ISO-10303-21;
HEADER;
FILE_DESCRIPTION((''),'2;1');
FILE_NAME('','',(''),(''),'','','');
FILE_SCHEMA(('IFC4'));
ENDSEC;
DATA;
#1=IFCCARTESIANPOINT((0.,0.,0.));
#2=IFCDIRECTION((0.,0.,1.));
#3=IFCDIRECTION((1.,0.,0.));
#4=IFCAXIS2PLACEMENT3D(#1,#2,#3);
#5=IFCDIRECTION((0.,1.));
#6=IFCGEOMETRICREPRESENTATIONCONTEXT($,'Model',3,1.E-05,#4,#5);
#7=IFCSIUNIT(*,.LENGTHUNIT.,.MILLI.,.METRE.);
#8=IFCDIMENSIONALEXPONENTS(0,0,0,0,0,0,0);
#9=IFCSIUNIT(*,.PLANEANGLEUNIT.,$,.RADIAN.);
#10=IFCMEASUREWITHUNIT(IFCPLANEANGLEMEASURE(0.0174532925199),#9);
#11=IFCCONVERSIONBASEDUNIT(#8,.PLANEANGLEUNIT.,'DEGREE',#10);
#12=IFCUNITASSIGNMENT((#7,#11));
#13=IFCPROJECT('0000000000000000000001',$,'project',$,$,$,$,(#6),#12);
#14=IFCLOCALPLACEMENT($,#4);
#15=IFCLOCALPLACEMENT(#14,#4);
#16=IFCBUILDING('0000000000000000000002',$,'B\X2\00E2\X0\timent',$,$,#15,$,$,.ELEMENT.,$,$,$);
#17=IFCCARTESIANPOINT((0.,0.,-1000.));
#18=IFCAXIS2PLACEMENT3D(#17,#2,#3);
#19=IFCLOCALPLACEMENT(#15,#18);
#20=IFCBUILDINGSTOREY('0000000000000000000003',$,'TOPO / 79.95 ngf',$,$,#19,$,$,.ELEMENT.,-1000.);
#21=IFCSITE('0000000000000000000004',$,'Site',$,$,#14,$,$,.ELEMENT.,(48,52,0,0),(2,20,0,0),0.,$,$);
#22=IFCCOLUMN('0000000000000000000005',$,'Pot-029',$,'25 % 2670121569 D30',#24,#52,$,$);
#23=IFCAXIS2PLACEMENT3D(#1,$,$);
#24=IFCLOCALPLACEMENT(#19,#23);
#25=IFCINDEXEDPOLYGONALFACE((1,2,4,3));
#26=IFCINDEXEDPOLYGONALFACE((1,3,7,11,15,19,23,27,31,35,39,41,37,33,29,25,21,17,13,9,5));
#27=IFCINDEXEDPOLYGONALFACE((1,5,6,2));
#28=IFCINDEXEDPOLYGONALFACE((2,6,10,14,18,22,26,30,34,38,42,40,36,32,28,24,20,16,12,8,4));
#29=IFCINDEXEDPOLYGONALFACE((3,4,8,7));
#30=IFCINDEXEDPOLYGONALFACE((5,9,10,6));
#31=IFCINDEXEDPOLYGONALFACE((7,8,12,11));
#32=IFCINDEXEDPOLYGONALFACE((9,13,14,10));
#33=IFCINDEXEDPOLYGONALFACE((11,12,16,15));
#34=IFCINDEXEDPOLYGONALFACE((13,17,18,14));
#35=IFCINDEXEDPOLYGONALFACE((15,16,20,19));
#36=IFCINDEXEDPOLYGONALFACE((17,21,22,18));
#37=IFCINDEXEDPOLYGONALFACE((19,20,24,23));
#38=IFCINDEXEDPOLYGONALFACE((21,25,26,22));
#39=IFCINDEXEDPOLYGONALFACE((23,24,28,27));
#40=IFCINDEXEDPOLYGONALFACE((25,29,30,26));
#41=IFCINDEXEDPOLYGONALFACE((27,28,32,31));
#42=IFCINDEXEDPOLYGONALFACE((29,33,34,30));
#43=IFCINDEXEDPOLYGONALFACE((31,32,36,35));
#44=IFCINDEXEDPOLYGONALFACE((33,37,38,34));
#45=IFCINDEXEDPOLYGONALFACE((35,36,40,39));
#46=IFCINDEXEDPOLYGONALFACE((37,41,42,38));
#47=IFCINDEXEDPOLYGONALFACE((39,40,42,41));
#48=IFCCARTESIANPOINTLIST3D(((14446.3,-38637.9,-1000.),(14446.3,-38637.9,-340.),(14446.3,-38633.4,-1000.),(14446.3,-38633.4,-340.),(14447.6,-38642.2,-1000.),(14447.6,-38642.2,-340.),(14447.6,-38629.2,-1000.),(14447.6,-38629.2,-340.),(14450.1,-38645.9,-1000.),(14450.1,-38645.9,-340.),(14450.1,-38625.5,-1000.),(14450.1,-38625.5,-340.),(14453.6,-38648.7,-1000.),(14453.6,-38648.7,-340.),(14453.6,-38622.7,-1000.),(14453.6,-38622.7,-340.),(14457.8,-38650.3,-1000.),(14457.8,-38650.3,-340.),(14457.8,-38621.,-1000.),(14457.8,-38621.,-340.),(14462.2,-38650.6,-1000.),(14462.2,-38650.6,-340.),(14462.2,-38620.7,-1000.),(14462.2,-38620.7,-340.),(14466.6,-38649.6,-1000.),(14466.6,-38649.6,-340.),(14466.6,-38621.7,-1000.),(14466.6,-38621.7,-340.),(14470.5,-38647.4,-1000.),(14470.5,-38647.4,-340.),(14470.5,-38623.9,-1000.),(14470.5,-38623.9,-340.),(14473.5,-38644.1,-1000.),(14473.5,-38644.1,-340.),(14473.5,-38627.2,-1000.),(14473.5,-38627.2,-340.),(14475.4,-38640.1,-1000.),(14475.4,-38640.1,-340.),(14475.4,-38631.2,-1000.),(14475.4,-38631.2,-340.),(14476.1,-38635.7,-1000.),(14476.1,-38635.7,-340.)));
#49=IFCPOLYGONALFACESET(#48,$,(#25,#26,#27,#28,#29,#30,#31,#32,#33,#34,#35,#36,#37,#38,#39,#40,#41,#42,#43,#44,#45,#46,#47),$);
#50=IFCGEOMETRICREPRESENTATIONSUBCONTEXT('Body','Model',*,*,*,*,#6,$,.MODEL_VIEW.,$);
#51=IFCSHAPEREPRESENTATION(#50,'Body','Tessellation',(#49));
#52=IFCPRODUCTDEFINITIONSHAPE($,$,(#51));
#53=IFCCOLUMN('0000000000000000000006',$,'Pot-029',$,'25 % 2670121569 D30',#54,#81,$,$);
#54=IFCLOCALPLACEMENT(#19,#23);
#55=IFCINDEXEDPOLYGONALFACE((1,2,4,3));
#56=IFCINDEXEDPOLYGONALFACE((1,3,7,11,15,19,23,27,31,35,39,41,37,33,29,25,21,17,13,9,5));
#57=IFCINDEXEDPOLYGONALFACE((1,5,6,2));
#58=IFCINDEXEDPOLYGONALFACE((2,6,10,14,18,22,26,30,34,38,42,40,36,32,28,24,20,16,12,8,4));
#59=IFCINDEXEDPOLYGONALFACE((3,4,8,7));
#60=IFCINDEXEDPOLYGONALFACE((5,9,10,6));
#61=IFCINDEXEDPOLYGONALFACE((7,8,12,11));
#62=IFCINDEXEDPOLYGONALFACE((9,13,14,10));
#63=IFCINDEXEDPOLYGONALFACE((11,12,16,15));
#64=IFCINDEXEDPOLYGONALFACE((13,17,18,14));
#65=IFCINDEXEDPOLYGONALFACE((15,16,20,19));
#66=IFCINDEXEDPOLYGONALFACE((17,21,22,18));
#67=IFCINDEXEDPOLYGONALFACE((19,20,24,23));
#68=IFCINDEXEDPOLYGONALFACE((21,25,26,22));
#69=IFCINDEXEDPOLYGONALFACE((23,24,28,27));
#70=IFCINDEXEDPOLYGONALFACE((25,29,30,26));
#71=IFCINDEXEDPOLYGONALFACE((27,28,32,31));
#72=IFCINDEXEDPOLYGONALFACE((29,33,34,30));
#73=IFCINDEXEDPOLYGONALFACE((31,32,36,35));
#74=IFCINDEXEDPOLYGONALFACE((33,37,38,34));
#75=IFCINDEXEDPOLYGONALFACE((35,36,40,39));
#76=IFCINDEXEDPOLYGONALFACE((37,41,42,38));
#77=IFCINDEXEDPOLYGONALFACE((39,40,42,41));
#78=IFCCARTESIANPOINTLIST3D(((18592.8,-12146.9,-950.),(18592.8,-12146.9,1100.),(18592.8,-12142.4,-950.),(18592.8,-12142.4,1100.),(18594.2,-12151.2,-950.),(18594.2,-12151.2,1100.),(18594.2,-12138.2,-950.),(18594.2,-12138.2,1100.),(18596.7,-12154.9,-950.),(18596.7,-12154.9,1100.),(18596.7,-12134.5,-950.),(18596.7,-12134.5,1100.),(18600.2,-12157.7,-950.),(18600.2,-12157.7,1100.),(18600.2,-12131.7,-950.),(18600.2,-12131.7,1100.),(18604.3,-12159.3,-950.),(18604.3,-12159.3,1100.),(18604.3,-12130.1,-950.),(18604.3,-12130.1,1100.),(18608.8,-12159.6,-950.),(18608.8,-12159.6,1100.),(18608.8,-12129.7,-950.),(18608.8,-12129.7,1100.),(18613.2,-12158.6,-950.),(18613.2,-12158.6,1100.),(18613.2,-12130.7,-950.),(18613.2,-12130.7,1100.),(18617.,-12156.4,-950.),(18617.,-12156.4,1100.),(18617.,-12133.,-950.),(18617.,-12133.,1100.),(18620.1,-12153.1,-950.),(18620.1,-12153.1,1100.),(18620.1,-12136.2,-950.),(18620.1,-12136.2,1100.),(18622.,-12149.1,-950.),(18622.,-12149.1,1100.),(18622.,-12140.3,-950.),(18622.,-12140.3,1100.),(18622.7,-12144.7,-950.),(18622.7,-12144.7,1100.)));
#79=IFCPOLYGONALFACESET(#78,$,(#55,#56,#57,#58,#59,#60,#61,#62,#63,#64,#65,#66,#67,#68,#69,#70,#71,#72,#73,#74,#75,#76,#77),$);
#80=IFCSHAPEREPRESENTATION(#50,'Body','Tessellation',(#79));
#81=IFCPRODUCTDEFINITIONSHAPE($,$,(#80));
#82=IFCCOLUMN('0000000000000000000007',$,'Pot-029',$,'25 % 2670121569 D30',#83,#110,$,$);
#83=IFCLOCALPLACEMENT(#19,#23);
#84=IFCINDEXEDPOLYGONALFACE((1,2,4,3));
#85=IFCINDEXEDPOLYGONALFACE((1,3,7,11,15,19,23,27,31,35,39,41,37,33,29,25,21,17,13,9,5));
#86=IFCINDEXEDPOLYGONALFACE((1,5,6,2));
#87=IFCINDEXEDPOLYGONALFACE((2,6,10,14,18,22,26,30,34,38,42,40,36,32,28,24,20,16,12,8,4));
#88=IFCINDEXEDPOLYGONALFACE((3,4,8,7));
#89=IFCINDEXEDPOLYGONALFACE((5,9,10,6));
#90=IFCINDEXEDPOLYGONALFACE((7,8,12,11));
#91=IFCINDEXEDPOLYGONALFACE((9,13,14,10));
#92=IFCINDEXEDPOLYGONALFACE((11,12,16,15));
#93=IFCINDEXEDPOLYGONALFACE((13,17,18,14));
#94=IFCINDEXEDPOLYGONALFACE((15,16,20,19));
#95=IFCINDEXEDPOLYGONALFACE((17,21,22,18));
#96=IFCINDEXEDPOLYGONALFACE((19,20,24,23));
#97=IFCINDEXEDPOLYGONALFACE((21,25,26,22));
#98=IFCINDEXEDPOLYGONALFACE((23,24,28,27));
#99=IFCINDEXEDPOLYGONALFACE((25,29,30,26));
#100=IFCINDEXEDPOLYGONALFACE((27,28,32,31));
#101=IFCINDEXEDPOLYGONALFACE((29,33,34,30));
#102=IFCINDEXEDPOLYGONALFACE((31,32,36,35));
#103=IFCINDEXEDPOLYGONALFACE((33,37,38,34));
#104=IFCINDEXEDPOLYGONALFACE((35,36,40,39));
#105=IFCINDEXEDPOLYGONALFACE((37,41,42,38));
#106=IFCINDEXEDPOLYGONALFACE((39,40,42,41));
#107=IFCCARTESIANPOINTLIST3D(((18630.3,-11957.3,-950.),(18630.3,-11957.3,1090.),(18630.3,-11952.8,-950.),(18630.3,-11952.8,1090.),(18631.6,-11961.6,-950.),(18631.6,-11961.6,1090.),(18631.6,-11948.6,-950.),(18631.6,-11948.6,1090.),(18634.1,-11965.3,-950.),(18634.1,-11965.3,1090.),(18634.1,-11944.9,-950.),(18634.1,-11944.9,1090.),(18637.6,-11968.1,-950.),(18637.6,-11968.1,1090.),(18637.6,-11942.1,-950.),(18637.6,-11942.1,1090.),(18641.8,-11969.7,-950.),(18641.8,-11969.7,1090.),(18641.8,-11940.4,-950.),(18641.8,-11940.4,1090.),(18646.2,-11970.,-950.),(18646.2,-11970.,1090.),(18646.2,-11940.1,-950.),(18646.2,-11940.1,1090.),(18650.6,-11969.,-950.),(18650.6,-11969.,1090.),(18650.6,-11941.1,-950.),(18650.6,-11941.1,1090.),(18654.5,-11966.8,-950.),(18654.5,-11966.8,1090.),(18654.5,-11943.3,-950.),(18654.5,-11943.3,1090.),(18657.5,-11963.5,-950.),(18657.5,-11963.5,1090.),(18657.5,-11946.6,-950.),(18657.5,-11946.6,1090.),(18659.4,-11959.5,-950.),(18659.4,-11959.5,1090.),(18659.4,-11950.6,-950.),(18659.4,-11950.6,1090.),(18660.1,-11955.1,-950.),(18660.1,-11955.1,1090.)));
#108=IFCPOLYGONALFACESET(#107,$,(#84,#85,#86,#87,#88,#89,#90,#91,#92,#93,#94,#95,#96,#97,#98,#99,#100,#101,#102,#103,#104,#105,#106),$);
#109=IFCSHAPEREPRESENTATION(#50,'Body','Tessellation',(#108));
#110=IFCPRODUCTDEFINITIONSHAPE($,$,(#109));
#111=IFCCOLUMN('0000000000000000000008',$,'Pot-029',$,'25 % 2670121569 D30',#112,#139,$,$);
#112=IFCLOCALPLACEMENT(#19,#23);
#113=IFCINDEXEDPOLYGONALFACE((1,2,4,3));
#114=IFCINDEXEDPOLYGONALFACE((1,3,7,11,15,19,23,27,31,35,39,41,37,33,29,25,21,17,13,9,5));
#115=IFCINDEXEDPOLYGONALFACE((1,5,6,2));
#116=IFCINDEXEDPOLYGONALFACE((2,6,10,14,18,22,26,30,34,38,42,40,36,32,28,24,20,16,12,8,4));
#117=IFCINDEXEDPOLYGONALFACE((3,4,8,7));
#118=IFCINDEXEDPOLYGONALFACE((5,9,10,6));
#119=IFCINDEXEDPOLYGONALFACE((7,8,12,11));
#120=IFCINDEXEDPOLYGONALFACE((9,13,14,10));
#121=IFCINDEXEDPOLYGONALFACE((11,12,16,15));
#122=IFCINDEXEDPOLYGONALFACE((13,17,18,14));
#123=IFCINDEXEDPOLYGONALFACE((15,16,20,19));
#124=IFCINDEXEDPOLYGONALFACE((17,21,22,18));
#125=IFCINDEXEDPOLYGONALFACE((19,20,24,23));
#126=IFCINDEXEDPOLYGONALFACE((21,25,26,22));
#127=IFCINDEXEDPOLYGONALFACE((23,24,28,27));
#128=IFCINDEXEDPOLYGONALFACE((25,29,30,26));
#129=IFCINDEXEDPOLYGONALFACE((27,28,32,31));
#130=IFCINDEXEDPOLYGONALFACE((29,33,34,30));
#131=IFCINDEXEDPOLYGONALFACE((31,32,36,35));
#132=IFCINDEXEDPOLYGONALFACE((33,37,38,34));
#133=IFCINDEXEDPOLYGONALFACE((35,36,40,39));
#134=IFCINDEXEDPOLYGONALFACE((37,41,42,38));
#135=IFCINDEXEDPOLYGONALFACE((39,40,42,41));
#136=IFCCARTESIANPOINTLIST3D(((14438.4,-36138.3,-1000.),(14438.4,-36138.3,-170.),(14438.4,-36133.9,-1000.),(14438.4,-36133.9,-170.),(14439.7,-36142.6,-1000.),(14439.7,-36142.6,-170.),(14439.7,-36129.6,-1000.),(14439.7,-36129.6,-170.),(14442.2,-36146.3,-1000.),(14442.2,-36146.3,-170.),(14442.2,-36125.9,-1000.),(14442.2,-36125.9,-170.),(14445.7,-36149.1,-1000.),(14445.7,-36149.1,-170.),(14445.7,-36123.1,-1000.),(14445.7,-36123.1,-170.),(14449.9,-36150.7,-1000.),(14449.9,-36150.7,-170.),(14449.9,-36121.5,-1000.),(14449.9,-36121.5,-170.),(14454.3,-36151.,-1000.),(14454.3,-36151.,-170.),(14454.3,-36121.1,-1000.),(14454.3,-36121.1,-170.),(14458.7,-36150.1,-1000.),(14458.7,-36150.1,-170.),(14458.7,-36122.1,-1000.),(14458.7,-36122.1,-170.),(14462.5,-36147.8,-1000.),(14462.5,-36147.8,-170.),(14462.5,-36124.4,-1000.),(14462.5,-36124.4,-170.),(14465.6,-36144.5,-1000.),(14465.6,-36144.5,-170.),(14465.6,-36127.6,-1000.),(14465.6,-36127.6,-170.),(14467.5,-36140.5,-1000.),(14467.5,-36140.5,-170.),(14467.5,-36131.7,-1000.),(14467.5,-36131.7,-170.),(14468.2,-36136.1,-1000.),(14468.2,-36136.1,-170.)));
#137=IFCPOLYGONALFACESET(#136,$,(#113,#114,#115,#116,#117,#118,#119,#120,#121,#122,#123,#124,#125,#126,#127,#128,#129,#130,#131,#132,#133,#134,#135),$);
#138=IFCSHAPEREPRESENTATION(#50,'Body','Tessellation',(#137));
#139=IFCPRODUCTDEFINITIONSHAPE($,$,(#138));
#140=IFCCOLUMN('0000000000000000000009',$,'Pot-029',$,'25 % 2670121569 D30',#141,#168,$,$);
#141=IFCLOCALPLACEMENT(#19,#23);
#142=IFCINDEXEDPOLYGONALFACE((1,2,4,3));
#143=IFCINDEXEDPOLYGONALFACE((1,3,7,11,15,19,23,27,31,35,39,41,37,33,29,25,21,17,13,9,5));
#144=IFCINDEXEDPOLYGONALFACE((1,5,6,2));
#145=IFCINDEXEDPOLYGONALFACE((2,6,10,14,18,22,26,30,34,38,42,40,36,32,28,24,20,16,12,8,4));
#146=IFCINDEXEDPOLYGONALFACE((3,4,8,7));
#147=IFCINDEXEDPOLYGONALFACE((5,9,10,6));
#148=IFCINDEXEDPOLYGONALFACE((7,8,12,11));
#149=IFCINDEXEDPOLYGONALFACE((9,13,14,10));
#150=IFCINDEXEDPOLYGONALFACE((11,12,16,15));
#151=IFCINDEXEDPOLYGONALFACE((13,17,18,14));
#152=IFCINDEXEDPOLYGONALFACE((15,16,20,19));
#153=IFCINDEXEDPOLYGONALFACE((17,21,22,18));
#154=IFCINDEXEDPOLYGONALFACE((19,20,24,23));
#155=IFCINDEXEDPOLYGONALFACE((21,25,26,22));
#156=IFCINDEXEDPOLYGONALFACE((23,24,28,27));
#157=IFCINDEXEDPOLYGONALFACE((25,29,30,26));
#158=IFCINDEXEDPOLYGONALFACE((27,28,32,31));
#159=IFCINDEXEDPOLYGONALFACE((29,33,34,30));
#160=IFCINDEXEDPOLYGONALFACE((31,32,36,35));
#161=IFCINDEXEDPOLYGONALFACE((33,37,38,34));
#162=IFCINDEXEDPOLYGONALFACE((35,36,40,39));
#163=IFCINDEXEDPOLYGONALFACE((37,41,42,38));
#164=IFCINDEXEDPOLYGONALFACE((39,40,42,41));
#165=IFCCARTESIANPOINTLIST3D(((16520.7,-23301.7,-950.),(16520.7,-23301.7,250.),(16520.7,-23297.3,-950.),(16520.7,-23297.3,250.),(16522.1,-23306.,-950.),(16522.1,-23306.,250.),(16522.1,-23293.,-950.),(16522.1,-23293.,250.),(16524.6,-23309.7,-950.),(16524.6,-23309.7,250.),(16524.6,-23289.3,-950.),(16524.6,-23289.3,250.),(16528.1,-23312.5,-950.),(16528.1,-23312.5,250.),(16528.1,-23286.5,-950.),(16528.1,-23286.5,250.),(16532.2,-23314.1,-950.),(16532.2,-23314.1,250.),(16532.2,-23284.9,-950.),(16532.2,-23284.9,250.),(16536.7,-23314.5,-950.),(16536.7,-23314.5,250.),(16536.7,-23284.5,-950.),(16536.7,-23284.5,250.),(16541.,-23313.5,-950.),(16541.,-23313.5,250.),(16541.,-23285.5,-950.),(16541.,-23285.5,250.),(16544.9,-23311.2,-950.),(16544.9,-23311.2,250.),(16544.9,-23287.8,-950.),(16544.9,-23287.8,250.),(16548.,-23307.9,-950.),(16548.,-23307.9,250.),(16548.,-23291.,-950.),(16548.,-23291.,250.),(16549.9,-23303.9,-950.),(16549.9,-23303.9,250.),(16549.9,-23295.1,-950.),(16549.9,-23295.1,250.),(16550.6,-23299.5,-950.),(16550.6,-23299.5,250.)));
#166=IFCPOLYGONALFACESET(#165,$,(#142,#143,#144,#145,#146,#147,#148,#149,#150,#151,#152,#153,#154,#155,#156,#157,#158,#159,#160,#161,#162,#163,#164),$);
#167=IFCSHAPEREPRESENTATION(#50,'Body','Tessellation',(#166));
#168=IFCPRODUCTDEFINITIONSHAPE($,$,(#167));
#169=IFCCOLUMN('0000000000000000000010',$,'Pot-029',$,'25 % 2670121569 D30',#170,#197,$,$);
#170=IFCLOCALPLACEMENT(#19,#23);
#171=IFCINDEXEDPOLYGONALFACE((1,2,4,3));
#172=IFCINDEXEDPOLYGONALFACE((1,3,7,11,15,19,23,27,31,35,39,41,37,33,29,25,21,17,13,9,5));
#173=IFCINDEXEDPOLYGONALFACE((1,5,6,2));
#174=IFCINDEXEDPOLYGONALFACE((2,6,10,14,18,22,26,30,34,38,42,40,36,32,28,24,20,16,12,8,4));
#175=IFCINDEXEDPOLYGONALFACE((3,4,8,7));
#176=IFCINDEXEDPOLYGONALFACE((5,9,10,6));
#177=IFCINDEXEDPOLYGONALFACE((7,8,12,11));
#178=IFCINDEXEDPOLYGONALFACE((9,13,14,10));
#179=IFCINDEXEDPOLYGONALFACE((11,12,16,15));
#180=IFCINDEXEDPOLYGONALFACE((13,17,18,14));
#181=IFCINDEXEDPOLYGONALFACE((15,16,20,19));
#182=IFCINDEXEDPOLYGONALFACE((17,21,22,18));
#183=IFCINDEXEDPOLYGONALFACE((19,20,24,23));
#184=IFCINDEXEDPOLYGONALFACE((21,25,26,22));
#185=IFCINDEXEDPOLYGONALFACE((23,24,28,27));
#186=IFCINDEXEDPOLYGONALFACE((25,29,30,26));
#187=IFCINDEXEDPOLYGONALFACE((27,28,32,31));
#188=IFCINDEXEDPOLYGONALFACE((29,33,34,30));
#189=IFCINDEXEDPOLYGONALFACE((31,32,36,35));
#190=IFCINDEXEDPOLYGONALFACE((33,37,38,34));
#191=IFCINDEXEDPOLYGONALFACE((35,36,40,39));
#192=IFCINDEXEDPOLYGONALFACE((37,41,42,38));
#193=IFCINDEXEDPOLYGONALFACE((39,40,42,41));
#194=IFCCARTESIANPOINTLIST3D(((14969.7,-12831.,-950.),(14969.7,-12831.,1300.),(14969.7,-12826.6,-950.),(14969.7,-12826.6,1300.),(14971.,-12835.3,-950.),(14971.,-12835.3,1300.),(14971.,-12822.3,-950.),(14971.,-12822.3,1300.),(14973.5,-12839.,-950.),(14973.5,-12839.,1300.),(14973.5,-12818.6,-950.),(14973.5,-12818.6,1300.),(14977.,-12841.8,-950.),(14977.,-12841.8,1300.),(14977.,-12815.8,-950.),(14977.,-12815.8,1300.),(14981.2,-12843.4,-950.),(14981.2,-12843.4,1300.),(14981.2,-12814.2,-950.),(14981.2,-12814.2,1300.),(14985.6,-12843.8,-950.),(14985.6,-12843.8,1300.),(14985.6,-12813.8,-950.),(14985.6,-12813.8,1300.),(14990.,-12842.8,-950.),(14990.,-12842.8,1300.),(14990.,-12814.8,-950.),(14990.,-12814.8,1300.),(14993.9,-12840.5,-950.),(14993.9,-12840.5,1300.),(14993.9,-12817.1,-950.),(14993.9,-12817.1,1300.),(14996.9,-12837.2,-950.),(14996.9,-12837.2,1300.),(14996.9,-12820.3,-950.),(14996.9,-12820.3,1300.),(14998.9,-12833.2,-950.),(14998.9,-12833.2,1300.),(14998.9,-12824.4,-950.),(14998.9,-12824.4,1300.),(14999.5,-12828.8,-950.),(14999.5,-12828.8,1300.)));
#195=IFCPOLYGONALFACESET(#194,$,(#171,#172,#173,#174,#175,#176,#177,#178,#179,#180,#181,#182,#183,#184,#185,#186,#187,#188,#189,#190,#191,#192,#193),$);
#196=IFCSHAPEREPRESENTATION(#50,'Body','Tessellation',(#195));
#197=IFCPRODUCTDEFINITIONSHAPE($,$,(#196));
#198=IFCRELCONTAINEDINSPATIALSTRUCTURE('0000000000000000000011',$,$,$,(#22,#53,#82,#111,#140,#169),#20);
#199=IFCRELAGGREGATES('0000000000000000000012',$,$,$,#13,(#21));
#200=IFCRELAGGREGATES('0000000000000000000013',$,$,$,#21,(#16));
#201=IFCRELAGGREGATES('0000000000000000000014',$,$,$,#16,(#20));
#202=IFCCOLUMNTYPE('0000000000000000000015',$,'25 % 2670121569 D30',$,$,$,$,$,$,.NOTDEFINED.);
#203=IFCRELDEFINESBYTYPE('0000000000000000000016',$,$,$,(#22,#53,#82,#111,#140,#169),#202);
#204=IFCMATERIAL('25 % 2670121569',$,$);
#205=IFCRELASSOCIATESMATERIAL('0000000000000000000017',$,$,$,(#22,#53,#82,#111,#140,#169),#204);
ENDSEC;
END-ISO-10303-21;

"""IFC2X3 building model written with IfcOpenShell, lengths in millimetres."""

from ifc_helpers import new_model, entity, si_unit, converted_unit, direction, frame, origin_with_axes, origin_2d_with_axis, place, context, subcontext, project, spatial, circle, extrude, material, type_object, element, save


model = new_model("IFC2X3")

# Units and contexts
model_context = context("Model", 3, precision=1e-05, world=origin_with_axes(), true_north=direction((0.0, 1.0)))
body_context = subcontext(model_context, "Body", "Model", "MODEL_VIEW")
ifc_project = project(units=[si_unit("LENGTHUNIT", "METRE", prefix="MILLI"), converted_unit("PLANEANGLEUNIT", "DEGREE", entity("IfcPlaneAngleMeasure", 0.0174532925199), si_unit("PLANEANGLEUNIT", "RADIAN"), dimensions=[0, 0, 0, 0, 0, 0, 0])], contexts=[model_context])

# Site, building, storey
site_placement = place(None, origin_with_axes())
site = spatial("IfcSite", under=ifc_project, at=site_placement, Name="Site", CompositionType="ELEMENT", RefLatitude=(48, 52, 0, 0), RefLongitude=(2, 20, 0, 0), RefElevation=0.0)
building_placement = place(site_placement, origin_with_axes())
building = spatial("IfcBuilding", under=site, at=building_placement, Name="Bâtiment", CompositionType="ELEMENT")
storey_placement = place(building_placement, frame((0.0, 0.0, -1000.0), z_axis=(0.0, 0.0, 1.0), x_axis=(1.0, 0.0, 0.0)))
storey = spatial("IfcBuildingStorey", under=building, at=storey_placement, Name="TOPO / 79.95 ngf", CompositionType="ELEMENT", Elevation=-1000.0)

# Columns
ifc_material_1 = material(Name="25 % 2670121569")
column_type = type_object("IfcColumnType", Name="25 % 2670121569 D30", PredefinedType="NOTDEFINED")
column_1_placement = place(storey_placement, frame((14461.1, -38635.7, -1000.0), z_axis=(0.0, 0.0, 1.0), x_axis=(1.0, 0.0, 0.0)))
element("IfcColumn", 1, at=column_1_placement, inside=storey, type_object=column_type, material=ifc_material_1, Name="Pot-029", ObjectType="25 % 2670121569 D30", context=body_context, shape_type="SweptSolid", body=[
    extrude(circle(Radius=15.0, at=origin_2d_with_axis()), origin_with_axes(), (0.0, 0.0, 1.0), 660.0),
])
column_2_placement = place(storey_placement, frame((18607.7, -12144.7, -950.0), z_axis=(0.0, 0.0, 1.0), x_axis=(1.0, 0.0, 0.0)))
element("IfcColumn", 2, at=column_2_placement, inside=storey, type_object=column_type, material=ifc_material_1, Name="Pot-029", ObjectType="25 % 2670121569 D30", context=body_context, shape_type="SweptSolid", body=[
    extrude(circle(Radius=15.0, at=origin_2d_with_axis()), origin_with_axes(), (0.0, 0.0, 1.0), 2050.0),
])
column_3_placement = place(storey_placement, frame((18645.1, -11955.1, -950.0), z_axis=(0.0, 0.0, 1.0), x_axis=(1.0, 0.0, 0.0)))
element("IfcColumn", 3, at=column_3_placement, inside=storey, type_object=column_type, material=ifc_material_1, Name="Pot-029", ObjectType="25 % 2670121569 D30", context=body_context, shape_type="SweptSolid", body=[
    extrude(circle(Radius=15.0, at=origin_2d_with_axis()), origin_with_axes(), (0.0, 0.0, 1.0), 2040.0),
])
column_4_placement = place(storey_placement, frame((14453.2, -36136.1, -1000.0), z_axis=(0.0, 0.0, 1.0), x_axis=(1.0, 0.0, 0.0)))
element("IfcColumn", 4, at=column_4_placement, inside=storey, type_object=column_type, material=ifc_material_1, Name="Pot-029", ObjectType="25 % 2670121569 D30", context=body_context, shape_type="SweptSolid", body=[
    extrude(circle(Radius=15.0, at=origin_2d_with_axis()), origin_with_axes(), (0.0, 0.0, 1.0), 830.0),
])
column_5_placement = place(storey_placement, frame((16535.6, -23299.5, -950.0), z_axis=(0.0, 0.0, 1.0), x_axis=(1.0, 0.0, 0.0)))
element("IfcColumn", 5, at=column_5_placement, inside=storey, type_object=column_type, material=ifc_material_1, Name="Pot-029", ObjectType="25 % 2670121569 D30", context=body_context, shape_type="SweptSolid", body=[
    extrude(circle(Radius=15.0, at=origin_2d_with_axis()), origin_with_axes(), (0.0, 0.0, 1.0), 1200.0),
])
column_6_placement = place(storey_placement, frame((14984.5, -12828.8, -950.0), z_axis=(0.0, 0.0, 1.0), x_axis=(1.0, 0.0, 0.0)))
element("IfcColumn", 6, at=column_6_placement, inside=storey, type_object=column_type, material=ifc_material_1, Name="Pot-029", ObjectType="25 % 2670121569 D30", context=body_context, shape_type="SweptSolid", body=[
    extrude(circle(Radius=15.0, at=origin_2d_with_axis()), origin_with_axes(), (0.0, 0.0, 1.0), 2250.0),
])

save(model, "model.ifc")
